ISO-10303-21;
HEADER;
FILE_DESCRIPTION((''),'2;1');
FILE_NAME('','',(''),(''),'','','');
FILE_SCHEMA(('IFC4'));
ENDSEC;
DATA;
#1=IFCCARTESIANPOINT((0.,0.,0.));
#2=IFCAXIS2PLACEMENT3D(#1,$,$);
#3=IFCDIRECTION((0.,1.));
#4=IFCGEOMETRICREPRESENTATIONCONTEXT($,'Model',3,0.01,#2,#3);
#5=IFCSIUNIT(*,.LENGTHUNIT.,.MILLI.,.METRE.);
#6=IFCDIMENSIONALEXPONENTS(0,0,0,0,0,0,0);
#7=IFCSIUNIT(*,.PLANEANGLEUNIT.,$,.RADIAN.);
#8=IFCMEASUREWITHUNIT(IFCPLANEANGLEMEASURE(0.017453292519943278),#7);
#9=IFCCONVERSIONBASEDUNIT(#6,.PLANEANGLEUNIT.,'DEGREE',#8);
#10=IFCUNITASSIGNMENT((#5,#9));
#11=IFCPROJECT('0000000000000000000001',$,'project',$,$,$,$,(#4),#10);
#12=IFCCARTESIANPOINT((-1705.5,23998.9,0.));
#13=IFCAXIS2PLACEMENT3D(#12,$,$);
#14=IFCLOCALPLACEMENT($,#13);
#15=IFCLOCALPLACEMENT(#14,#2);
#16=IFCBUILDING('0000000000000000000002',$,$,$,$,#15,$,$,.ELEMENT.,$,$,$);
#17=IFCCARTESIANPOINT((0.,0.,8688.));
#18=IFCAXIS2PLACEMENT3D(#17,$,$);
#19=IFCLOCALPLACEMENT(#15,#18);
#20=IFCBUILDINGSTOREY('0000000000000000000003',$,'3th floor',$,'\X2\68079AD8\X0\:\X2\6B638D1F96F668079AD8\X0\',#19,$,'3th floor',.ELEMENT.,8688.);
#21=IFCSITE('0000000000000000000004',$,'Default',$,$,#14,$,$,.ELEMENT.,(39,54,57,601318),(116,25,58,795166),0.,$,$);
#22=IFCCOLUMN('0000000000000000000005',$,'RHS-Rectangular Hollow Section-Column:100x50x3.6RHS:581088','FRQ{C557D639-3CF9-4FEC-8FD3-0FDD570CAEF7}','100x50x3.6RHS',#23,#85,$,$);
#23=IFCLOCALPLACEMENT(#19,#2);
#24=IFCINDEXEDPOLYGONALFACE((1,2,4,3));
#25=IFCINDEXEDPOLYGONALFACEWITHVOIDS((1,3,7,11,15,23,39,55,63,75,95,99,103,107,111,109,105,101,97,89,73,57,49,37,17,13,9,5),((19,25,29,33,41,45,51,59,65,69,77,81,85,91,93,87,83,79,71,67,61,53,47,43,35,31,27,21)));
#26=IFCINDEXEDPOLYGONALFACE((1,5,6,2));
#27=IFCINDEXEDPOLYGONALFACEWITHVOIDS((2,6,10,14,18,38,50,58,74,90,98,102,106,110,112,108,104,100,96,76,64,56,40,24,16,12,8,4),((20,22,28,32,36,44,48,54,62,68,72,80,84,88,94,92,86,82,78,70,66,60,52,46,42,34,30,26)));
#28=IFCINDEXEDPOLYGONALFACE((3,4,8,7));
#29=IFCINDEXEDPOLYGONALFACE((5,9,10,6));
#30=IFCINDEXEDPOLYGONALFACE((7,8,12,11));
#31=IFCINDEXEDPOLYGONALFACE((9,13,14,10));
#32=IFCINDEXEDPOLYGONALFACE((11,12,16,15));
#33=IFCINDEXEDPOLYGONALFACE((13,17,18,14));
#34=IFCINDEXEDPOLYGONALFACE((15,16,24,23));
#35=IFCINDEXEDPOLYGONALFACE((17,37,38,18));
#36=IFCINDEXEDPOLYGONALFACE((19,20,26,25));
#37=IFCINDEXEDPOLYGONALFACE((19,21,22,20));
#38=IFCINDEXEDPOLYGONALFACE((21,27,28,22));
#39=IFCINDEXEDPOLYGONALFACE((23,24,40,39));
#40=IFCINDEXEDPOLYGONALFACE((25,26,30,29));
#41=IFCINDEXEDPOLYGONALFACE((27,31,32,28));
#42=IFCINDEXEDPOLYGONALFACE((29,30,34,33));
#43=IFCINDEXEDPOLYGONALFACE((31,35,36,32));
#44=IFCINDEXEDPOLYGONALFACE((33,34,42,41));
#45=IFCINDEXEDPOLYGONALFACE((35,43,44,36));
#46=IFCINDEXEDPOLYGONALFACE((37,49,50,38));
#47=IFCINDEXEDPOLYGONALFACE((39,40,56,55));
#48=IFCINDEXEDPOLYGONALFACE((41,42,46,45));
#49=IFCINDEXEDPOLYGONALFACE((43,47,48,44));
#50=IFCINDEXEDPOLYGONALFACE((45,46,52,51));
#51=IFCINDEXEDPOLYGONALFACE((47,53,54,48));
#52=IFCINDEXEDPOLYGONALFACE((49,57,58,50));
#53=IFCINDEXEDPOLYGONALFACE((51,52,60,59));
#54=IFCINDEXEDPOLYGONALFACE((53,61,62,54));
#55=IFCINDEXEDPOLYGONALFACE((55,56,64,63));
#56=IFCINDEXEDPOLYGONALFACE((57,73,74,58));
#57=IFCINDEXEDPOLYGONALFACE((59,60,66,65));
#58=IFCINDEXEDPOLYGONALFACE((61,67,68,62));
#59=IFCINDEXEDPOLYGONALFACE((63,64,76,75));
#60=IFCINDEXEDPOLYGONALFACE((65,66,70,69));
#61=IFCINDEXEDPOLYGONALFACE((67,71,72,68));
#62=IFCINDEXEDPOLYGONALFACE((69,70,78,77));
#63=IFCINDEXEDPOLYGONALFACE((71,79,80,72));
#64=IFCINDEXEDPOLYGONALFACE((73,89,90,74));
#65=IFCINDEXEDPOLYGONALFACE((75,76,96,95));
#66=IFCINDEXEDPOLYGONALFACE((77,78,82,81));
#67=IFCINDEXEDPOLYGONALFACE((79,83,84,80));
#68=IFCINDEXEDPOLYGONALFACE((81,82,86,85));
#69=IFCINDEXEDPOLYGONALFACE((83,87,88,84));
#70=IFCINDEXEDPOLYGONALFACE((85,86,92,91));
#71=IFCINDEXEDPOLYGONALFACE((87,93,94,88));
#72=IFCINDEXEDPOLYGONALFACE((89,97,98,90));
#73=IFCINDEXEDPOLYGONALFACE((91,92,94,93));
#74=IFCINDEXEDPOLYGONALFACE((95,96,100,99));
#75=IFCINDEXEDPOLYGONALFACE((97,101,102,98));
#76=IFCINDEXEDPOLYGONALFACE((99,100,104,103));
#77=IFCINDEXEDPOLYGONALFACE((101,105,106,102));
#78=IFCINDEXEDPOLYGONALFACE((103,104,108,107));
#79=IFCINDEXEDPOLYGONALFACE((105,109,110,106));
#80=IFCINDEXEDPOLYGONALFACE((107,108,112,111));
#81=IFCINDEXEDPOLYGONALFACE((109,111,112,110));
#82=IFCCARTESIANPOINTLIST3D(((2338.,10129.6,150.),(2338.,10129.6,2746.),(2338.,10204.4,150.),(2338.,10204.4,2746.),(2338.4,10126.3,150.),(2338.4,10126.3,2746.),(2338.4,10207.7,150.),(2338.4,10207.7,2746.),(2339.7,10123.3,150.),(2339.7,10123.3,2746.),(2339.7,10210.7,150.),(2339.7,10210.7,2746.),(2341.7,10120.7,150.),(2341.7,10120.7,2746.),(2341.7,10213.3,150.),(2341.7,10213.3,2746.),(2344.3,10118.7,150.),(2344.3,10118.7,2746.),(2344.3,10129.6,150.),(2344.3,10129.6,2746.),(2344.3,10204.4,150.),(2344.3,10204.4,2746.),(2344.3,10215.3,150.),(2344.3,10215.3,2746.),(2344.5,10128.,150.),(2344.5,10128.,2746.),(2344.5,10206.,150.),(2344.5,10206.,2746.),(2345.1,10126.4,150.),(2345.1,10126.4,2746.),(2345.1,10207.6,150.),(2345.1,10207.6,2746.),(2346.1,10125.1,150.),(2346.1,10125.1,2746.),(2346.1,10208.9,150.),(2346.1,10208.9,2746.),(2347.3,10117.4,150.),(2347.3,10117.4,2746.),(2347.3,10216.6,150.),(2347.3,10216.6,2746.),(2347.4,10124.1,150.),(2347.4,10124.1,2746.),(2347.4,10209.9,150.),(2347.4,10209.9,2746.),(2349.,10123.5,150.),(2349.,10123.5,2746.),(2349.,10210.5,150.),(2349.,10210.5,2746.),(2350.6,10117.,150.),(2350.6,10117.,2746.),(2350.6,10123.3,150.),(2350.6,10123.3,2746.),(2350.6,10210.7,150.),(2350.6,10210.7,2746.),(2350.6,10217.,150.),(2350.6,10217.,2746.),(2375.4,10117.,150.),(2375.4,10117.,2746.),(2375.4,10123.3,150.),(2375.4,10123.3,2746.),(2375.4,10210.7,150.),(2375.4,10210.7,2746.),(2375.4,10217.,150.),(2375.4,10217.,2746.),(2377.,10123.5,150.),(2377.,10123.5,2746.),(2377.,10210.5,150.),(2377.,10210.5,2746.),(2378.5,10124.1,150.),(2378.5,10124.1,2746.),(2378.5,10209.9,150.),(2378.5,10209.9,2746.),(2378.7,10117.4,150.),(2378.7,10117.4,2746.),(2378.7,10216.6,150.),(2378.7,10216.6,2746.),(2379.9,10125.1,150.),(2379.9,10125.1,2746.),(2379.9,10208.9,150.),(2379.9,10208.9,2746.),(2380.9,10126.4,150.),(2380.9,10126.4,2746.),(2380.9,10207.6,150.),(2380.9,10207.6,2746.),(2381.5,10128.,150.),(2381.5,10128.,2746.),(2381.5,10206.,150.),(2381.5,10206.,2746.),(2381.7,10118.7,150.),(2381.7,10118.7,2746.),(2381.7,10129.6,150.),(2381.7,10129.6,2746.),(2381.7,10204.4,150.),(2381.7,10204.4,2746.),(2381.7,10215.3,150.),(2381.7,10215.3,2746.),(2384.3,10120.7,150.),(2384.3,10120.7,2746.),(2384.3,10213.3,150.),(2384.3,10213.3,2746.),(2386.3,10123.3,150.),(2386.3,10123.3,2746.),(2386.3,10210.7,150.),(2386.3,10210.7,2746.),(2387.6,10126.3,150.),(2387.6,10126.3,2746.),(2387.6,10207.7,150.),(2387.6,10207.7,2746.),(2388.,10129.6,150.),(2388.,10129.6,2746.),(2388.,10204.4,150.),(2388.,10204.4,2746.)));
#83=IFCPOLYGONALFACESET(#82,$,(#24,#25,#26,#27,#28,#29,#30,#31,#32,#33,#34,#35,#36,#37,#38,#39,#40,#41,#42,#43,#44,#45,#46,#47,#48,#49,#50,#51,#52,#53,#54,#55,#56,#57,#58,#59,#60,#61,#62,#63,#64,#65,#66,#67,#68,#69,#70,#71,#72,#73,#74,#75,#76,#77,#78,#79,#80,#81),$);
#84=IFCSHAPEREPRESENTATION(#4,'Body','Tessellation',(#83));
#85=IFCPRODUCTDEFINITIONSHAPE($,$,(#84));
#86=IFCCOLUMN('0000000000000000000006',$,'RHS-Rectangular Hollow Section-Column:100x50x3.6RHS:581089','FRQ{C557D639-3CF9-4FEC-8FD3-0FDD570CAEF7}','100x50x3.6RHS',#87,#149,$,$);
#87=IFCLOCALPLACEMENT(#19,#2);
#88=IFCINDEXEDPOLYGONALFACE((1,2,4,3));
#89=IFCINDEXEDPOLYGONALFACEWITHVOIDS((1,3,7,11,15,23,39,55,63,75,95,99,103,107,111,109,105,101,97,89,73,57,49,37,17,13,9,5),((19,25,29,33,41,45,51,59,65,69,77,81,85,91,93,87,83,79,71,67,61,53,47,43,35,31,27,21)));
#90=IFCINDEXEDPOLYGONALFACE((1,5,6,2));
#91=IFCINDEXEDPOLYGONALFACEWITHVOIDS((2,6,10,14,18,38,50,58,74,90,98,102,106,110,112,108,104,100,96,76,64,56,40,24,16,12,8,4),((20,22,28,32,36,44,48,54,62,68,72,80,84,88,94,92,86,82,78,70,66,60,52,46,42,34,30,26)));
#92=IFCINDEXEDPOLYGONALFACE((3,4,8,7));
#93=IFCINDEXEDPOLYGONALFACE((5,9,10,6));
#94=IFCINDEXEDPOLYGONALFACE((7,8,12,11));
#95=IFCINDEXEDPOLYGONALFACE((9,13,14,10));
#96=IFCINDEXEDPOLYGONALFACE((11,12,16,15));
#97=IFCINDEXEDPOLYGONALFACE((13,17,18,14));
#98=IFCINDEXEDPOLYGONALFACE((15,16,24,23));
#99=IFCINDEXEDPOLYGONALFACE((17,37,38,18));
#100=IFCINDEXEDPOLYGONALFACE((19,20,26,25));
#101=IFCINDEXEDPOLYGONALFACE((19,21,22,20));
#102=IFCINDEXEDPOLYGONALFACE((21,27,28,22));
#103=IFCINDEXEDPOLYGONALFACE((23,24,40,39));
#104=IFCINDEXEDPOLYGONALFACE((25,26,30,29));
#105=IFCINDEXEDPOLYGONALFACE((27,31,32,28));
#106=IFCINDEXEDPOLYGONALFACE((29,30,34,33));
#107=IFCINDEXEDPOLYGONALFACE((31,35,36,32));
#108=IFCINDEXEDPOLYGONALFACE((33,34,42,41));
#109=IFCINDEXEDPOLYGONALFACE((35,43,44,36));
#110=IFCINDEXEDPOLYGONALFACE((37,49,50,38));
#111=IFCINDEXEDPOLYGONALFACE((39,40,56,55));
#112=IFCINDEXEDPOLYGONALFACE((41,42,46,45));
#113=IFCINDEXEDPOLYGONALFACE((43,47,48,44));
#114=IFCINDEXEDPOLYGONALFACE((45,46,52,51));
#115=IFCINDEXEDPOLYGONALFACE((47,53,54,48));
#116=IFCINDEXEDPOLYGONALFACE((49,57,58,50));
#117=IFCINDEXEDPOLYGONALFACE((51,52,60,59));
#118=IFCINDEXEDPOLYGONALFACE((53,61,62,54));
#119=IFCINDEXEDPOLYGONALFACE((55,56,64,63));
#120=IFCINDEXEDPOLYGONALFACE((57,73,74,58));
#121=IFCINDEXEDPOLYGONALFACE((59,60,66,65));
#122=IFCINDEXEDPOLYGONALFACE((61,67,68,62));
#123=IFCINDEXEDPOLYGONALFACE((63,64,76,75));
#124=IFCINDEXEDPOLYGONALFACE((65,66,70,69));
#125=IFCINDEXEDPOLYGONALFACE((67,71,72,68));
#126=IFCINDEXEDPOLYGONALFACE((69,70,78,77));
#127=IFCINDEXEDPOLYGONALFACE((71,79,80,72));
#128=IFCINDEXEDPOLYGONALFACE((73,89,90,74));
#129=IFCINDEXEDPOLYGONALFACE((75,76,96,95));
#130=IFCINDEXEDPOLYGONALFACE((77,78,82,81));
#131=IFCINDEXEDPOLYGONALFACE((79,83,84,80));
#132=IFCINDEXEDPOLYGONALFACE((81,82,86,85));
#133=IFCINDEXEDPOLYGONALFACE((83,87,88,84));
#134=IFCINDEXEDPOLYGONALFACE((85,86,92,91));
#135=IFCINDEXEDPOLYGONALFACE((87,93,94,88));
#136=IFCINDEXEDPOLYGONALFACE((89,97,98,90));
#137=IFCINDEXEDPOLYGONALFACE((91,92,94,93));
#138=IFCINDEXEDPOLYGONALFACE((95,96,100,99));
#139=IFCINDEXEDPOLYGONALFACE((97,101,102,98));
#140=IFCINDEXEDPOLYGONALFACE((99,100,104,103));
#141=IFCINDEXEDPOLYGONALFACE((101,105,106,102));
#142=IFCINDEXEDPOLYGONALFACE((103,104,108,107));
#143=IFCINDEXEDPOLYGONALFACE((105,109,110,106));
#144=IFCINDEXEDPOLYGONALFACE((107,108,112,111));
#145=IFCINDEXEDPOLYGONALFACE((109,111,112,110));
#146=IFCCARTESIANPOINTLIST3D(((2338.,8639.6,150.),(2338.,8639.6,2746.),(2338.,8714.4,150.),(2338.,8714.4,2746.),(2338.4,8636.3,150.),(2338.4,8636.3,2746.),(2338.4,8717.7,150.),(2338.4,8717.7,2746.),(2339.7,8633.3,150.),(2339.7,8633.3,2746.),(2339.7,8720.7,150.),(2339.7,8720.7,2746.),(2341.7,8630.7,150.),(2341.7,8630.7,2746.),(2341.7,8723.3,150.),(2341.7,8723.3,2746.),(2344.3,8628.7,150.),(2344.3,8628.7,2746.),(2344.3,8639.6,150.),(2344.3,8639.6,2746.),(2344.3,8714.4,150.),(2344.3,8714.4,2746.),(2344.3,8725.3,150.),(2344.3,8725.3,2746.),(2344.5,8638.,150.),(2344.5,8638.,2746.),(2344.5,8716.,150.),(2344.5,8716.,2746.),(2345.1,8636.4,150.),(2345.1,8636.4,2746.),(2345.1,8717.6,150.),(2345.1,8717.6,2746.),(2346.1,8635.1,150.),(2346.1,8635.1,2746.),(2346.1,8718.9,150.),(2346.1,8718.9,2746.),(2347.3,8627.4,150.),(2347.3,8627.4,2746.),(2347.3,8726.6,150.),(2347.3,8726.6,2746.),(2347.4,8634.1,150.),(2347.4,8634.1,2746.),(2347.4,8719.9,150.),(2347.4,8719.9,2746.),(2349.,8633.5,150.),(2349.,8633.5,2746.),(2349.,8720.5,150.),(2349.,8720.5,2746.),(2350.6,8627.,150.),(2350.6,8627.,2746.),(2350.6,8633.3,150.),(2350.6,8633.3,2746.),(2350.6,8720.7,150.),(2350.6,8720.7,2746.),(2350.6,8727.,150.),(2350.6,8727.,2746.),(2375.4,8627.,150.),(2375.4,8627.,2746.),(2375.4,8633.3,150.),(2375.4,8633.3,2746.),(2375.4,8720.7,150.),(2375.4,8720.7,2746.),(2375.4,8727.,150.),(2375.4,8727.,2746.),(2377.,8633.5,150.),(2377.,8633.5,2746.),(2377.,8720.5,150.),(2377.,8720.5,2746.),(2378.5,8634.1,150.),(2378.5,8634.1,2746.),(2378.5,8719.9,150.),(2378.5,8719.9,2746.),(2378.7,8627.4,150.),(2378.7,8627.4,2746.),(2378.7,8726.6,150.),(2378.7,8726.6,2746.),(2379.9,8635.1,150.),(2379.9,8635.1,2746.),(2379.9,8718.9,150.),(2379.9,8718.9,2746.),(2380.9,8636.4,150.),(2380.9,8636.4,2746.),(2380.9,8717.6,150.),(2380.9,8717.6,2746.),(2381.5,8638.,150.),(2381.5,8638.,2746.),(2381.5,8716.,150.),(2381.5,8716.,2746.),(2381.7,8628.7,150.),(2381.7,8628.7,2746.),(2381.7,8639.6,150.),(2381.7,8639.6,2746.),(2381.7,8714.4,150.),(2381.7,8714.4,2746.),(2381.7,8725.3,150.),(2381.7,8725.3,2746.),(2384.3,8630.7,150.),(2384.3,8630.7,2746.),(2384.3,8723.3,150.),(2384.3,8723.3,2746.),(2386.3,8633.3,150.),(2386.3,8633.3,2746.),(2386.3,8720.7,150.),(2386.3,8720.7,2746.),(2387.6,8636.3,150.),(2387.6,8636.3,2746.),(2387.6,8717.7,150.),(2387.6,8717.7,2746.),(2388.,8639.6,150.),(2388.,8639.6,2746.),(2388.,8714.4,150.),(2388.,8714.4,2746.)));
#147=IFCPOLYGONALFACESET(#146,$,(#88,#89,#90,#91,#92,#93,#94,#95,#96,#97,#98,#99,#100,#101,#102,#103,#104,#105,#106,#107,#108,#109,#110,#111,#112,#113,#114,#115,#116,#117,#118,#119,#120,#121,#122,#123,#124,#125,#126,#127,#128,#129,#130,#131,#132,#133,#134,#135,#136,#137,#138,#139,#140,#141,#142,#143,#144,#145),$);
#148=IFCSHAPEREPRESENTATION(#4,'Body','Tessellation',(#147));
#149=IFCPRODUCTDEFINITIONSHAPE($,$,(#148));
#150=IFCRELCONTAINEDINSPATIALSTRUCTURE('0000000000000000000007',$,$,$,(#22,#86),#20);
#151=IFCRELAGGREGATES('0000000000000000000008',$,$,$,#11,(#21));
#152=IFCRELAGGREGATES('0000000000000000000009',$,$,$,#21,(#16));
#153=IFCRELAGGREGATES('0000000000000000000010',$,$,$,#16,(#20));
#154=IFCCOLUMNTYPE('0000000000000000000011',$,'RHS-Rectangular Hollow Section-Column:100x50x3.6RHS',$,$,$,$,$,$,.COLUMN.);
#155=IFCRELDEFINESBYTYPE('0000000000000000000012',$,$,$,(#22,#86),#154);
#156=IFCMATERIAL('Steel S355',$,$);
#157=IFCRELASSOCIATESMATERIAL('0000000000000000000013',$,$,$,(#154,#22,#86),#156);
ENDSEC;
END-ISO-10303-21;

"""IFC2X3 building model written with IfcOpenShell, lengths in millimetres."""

from ifc_helpers import new_model, entity, si_unit, converted_unit, direction, frame, origin, origin_2d, place, context, project, spatial, hollow_rectangle, extrude, clip, halfspace, material, type_object, element, save


model = new_model("IFC2X3")

# Units and contexts
model_context = context("Model", 3, precision=0.01, world=origin(), true_north=direction((0.0, 1.0)))
ifc_project = project(units=[si_unit("LENGTHUNIT", "METRE", prefix="MILLI"), converted_unit("PLANEANGLEUNIT", "DEGREE", entity("IfcPlaneAngleMeasure", 0.017453292519943278), si_unit("PLANEANGLEUNIT", "RADIAN"), dimensions=[0, 0, 0, 0, 0, 0, 0])], contexts=[model_context])

# Site, building, storey
site_placement = place(None, frame((-1705.5, 23998.9, 0.0)))
site = spatial("IfcSite", under=ifc_project, at=site_placement, Name="Default", CompositionType="ELEMENT", RefLatitude=(39, 54, 57, 601318), RefLongitude=(116, 25, 58, 795166), RefElevation=0.0)
building_placement = place(site_placement, origin())
building = spatial("IfcBuilding", under=site, at=building_placement, CompositionType="ELEMENT")
storey_placement = place(building_placement, frame((0.0, 0.0, 8688.0)))
storey = spatial("IfcBuildingStorey", under=building, at=storey_placement, Name="3th floor", ObjectType="标高:正负零标高", LongName="3th floor", CompositionType="ELEMENT", Elevation=8688.0)

# Columns
ifc_material_1 = material(Name="Steel S355")
column_type = type_object("IfcColumnType", Name="RHS-Rectangular Hollow Section-Column:100x50x3.6RHS", PredefinedType="COLUMN", material=ifc_material_1)
column_1_placement = place(storey_placement, frame((2363.0, 10167.0, 2746.0), z_axis=(0.0, 0.0, 1.0), x_axis=(-1.0, 0.0, 0.0)))
element("IfcColumn", 1, at=column_1_placement, inside=storey, type_object=column_type, material=ifc_material_1, Name="RHS-Rectangular Hollow Section-Column:100x50x3.6RHS:581088", Description="FRQ{C557D639-3CF9-4FEC-8FD3-0FDD570CAEF7}", ObjectType="100x50x3.6RHS", context=model_context, shape_type="Clipping", body=[
    clip(extrude(hollow_rectangle(XDim=50.0, YDim=100.0, WallThickness=6.3, InnerFilletRadius=6.3, OuterFilletRadius=12.6, at=origin_2d()), origin(), (0.0, 0.0, -1.0), 2651.9), halfspace(frame((2363.0, 10167.0, -2596.0), z_axis=(0.0, 0.0, 1.0), x_axis=(-1.0, 0.0, 0.0)), True)),
])
column_2_placement = place(storey_placement, frame((2363.0, 8677.0, 2746.0), z_axis=(0.0, 0.0, 1.0), x_axis=(-1.0, 0.0, 0.0)))
element("IfcColumn", 2, at=column_2_placement, inside=storey, type_object=column_type, material=ifc_material_1, Name="RHS-Rectangular Hollow Section-Column:100x50x3.6RHS:581089", Description="FRQ{C557D639-3CF9-4FEC-8FD3-0FDD570CAEF7}", ObjectType="100x50x3.6RHS", context=model_context, shape_type="Clipping", body=[
    clip(extrude(hollow_rectangle(XDim=50.0, YDim=100.0, WallThickness=6.3, InnerFilletRadius=6.3, OuterFilletRadius=12.6, at=origin_2d()), origin(), (0.0, 0.0, -1.0), 2651.9), halfspace(frame((2363.0, 8677.0, -2596.0), z_axis=(0.0, 0.0, 1.0), x_axis=(-1.0, 0.0, 0.0)), True)),
])

save(model, "model.ifc")
